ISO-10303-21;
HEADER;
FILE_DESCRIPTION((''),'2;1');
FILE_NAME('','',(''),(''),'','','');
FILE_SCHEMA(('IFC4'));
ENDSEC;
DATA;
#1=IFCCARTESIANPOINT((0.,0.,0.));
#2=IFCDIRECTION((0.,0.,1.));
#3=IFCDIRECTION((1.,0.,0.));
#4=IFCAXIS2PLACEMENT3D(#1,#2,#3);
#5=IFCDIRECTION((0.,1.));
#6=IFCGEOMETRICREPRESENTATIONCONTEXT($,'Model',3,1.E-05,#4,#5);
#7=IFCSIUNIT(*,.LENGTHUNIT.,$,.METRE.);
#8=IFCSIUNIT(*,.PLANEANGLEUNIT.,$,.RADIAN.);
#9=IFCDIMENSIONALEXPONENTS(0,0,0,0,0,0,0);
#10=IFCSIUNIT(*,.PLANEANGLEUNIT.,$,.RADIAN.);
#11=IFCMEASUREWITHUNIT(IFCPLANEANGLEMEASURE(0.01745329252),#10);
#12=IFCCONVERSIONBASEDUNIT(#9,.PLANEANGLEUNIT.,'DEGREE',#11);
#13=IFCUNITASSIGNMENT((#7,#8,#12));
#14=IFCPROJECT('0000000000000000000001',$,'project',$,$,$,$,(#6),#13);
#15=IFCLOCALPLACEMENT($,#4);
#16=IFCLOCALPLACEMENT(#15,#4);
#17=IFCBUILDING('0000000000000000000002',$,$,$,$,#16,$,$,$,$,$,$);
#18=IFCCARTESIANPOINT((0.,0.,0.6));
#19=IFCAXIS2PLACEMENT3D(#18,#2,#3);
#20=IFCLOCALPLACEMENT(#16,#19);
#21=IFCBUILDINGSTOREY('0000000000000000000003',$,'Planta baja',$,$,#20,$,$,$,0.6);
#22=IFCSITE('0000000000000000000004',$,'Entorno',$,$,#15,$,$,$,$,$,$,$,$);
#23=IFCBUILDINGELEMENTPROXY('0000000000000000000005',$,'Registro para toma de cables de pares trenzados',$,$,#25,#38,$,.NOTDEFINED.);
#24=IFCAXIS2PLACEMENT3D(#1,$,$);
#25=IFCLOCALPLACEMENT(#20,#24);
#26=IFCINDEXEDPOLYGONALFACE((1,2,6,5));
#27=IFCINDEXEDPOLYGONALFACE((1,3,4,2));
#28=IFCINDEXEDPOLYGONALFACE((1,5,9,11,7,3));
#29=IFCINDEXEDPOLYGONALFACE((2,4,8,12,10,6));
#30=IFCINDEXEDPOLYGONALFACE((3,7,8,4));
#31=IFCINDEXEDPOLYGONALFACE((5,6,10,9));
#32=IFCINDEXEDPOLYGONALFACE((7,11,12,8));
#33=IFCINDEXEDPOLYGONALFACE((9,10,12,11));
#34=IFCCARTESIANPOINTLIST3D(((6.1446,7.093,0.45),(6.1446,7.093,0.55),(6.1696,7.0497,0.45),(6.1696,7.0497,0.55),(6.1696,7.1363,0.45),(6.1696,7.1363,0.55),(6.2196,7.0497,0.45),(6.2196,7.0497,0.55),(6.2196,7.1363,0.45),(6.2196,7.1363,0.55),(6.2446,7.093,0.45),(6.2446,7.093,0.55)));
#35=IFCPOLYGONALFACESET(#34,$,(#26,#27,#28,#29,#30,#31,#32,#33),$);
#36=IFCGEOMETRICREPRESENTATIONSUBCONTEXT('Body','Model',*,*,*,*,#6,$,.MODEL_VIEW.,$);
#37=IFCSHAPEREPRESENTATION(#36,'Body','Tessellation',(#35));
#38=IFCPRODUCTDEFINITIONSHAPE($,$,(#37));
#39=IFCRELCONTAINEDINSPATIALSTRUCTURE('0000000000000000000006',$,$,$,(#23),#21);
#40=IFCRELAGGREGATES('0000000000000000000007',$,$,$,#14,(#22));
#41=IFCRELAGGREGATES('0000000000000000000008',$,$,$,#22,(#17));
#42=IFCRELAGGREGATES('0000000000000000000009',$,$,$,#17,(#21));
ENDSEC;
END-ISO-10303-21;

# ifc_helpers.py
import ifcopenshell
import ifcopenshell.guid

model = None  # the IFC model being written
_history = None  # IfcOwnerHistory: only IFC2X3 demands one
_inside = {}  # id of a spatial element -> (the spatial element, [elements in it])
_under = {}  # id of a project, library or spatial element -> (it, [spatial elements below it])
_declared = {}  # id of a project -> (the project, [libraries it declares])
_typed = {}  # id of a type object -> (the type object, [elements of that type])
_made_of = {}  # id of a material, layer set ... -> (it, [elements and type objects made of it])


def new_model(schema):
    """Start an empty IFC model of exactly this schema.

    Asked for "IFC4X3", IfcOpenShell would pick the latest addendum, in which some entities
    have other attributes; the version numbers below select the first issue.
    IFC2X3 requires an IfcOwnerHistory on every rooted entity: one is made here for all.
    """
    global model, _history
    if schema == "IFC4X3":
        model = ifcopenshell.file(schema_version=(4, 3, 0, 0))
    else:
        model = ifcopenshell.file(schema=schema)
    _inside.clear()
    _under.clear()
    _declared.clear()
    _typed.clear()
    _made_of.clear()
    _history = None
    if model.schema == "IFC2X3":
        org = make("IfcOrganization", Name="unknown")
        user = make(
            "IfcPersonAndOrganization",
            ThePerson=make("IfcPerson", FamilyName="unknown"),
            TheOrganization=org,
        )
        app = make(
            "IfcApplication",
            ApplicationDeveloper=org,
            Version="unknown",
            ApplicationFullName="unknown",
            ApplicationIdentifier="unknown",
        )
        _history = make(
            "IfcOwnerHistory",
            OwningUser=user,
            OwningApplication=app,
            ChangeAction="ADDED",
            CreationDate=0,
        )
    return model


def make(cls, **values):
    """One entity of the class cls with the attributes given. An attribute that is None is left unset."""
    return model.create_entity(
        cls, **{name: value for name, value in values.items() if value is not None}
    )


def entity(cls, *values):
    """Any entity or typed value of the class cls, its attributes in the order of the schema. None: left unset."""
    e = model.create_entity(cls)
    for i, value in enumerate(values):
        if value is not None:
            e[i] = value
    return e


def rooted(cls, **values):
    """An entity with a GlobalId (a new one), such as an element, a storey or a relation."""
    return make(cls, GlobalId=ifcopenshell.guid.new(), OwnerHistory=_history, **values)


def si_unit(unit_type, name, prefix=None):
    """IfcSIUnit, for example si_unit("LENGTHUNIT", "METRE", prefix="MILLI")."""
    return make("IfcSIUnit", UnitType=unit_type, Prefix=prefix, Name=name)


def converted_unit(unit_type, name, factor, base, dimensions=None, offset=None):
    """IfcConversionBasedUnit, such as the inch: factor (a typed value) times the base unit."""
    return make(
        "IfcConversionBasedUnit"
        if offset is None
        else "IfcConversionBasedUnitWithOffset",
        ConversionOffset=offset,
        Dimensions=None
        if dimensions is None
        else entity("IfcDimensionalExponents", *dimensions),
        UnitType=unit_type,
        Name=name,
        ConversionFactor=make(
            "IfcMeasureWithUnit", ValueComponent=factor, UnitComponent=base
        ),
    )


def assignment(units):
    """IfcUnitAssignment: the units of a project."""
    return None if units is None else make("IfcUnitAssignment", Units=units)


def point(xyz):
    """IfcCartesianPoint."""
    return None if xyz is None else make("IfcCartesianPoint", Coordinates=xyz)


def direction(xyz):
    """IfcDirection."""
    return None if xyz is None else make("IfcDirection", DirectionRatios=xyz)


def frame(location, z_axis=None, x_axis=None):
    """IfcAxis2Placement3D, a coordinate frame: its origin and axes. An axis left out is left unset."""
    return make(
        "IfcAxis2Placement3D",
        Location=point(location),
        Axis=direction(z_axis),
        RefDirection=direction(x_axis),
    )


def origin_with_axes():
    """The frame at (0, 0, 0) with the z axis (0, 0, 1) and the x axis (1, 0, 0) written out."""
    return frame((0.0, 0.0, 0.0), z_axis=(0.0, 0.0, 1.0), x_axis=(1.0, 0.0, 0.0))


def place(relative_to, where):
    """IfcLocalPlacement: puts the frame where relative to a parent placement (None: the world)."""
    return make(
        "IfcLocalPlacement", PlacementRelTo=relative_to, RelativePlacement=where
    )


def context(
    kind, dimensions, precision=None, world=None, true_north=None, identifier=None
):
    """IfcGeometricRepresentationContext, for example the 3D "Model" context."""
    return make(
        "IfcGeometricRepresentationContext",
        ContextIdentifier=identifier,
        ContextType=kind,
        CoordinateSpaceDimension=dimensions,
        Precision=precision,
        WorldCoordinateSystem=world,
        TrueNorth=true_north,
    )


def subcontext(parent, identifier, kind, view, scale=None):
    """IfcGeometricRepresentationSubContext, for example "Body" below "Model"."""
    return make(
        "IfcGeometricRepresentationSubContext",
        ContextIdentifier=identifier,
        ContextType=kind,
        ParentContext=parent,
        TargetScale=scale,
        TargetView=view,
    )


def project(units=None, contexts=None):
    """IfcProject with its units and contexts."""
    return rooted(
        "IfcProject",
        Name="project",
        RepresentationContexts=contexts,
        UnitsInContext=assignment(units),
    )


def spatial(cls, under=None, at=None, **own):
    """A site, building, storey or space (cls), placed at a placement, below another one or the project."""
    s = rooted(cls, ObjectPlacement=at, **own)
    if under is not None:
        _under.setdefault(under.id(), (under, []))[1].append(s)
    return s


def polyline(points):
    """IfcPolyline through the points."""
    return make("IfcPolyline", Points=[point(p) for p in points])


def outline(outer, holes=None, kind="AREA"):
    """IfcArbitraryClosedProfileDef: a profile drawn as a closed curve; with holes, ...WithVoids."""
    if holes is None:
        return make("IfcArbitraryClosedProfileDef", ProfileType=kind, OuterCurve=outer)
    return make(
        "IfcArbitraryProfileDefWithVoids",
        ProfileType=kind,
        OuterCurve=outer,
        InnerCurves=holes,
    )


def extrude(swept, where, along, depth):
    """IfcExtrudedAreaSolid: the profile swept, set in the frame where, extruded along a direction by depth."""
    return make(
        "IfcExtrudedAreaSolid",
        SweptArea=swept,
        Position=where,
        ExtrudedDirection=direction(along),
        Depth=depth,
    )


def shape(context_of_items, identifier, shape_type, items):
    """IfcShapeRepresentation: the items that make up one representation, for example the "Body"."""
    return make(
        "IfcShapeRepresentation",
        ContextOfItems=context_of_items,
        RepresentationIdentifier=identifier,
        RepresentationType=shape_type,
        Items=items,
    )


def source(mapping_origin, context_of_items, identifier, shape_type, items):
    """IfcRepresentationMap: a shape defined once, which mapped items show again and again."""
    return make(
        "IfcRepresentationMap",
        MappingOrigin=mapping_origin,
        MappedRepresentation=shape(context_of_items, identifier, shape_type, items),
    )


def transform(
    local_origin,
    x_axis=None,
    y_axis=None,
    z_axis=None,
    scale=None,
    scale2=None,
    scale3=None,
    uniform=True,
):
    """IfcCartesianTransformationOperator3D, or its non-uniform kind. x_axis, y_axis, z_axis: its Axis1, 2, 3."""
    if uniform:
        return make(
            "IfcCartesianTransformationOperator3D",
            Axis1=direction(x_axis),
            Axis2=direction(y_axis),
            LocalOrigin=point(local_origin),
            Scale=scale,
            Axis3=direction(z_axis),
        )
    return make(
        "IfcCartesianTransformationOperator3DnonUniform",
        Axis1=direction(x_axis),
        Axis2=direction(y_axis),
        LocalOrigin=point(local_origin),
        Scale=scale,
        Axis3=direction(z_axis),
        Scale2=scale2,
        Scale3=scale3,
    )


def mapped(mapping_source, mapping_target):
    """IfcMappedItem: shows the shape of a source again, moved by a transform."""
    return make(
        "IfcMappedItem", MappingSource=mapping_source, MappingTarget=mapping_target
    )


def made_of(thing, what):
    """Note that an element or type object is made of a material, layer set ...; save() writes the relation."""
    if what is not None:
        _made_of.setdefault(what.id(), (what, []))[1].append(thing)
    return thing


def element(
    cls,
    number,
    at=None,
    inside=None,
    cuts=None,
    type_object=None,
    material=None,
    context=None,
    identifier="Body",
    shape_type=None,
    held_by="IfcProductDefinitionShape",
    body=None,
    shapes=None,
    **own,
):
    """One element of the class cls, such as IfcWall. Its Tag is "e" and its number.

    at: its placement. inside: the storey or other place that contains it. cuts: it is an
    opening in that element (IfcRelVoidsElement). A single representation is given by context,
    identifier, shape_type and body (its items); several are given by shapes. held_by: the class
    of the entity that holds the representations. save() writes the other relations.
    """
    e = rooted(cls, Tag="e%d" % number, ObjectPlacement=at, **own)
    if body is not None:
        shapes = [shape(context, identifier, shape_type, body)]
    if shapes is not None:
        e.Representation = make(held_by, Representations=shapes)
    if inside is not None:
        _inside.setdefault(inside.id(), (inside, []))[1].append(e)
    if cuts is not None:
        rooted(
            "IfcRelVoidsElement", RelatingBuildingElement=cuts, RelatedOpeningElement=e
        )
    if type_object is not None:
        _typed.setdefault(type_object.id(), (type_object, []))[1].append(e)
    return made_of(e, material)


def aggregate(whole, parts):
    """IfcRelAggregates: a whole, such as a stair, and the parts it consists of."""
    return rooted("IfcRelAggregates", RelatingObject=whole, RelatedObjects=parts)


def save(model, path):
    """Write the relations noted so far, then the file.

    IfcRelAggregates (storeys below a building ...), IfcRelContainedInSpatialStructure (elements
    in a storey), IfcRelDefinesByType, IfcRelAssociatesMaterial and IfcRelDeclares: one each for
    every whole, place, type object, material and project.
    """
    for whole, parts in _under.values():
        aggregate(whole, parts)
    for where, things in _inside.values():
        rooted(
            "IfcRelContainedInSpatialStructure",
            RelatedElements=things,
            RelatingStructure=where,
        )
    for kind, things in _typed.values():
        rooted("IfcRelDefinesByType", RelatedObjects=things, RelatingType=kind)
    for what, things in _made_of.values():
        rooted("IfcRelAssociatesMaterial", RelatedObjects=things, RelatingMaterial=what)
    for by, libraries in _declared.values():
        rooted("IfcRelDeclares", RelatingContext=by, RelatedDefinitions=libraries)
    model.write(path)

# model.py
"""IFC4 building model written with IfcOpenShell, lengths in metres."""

from ifc_helpers import new_model, entity, si_unit, converted_unit, direction, frame, origin_with_axes, place, context, subcontext, project, spatial, polyline, outline, extrude, source, transform, mapped, element, save


model = new_model("IFC4")

# Units and contexts
model_context = context("Model", 3, precision=1e-05, world=origin_with_axes(), true_north=direction((0.0, 1.0)))
body_context = subcontext(model_context, "Body", "Model", "MODEL_VIEW")
ifc_project = project(units=[si_unit("LENGTHUNIT", "METRE"), si_unit("PLANEANGLEUNIT", "RADIAN"), converted_unit("PLANEANGLEUNIT", "DEGREE", entity("IfcPlaneAngleMeasure", 0.01745329252), si_unit("PLANEANGLEUNIT", "RADIAN"), dimensions=[0, 0, 0, 0, 0, 0, 0])], contexts=[model_context])

# Site, building, storey
site_placement = place(None, origin_with_axes())
site = spatial("IfcSite", under=ifc_project, at=site_placement, Name="Entorno")
building_placement = place(site_placement, origin_with_axes())
building = spatial("IfcBuilding", under=site, at=building_placement)
storey_placement = place(building_placement, frame((0.0, 0.0, 0.6), z_axis=(0.0, 0.0, 1.0), x_axis=(1.0, 0.0, 0.0)))
storey = spatial("IfcBuildingStorey", under=building, at=storey_placement, Name="Planta baja", Elevation=0.6)

# Building element proxy
shared_shape_1 = source(origin_with_axes(), body_context, "Body", "SolidModel", [
    extrude(outline(polyline([(0.05, 0.0), (0.025, 0.0433), (-0.025, 0.0433), (-0.05, 0.0), (-0.025, -0.0433), (0.025, -0.0433), (0.05, 0.0)])), frame((0.0, 0.0, -0.05), z_axis=(0.0, 0.0, 1.0), x_axis=(1.0, 0.0, 0.0)), (0.0, 0.0, 1.0), 0.1),
])
proxy_1_placement = place(storey_placement, frame((0.0, 0.0, -0.6), z_axis=(0.0, 0.0, 1.0), x_axis=(1.0, 0.0, 0.0)))
element("IfcBuildingElementProxy", 1, at=proxy_1_placement, inside=storey, Name="Registro para toma de cables de pares trenzados", PredefinedType="NOTDEFINED", context=body_context, shape_type="Brep", body=[
    mapped(shared_shape_1, transform((6.1946, 7.093, 1.1), x_axis=(1.0, 0.0, 0.0), y_axis=(0.0, 1.0, 0.0), z_axis=(0.0, 0.0, 1.0))),
])

save(model, "model.ifc")
